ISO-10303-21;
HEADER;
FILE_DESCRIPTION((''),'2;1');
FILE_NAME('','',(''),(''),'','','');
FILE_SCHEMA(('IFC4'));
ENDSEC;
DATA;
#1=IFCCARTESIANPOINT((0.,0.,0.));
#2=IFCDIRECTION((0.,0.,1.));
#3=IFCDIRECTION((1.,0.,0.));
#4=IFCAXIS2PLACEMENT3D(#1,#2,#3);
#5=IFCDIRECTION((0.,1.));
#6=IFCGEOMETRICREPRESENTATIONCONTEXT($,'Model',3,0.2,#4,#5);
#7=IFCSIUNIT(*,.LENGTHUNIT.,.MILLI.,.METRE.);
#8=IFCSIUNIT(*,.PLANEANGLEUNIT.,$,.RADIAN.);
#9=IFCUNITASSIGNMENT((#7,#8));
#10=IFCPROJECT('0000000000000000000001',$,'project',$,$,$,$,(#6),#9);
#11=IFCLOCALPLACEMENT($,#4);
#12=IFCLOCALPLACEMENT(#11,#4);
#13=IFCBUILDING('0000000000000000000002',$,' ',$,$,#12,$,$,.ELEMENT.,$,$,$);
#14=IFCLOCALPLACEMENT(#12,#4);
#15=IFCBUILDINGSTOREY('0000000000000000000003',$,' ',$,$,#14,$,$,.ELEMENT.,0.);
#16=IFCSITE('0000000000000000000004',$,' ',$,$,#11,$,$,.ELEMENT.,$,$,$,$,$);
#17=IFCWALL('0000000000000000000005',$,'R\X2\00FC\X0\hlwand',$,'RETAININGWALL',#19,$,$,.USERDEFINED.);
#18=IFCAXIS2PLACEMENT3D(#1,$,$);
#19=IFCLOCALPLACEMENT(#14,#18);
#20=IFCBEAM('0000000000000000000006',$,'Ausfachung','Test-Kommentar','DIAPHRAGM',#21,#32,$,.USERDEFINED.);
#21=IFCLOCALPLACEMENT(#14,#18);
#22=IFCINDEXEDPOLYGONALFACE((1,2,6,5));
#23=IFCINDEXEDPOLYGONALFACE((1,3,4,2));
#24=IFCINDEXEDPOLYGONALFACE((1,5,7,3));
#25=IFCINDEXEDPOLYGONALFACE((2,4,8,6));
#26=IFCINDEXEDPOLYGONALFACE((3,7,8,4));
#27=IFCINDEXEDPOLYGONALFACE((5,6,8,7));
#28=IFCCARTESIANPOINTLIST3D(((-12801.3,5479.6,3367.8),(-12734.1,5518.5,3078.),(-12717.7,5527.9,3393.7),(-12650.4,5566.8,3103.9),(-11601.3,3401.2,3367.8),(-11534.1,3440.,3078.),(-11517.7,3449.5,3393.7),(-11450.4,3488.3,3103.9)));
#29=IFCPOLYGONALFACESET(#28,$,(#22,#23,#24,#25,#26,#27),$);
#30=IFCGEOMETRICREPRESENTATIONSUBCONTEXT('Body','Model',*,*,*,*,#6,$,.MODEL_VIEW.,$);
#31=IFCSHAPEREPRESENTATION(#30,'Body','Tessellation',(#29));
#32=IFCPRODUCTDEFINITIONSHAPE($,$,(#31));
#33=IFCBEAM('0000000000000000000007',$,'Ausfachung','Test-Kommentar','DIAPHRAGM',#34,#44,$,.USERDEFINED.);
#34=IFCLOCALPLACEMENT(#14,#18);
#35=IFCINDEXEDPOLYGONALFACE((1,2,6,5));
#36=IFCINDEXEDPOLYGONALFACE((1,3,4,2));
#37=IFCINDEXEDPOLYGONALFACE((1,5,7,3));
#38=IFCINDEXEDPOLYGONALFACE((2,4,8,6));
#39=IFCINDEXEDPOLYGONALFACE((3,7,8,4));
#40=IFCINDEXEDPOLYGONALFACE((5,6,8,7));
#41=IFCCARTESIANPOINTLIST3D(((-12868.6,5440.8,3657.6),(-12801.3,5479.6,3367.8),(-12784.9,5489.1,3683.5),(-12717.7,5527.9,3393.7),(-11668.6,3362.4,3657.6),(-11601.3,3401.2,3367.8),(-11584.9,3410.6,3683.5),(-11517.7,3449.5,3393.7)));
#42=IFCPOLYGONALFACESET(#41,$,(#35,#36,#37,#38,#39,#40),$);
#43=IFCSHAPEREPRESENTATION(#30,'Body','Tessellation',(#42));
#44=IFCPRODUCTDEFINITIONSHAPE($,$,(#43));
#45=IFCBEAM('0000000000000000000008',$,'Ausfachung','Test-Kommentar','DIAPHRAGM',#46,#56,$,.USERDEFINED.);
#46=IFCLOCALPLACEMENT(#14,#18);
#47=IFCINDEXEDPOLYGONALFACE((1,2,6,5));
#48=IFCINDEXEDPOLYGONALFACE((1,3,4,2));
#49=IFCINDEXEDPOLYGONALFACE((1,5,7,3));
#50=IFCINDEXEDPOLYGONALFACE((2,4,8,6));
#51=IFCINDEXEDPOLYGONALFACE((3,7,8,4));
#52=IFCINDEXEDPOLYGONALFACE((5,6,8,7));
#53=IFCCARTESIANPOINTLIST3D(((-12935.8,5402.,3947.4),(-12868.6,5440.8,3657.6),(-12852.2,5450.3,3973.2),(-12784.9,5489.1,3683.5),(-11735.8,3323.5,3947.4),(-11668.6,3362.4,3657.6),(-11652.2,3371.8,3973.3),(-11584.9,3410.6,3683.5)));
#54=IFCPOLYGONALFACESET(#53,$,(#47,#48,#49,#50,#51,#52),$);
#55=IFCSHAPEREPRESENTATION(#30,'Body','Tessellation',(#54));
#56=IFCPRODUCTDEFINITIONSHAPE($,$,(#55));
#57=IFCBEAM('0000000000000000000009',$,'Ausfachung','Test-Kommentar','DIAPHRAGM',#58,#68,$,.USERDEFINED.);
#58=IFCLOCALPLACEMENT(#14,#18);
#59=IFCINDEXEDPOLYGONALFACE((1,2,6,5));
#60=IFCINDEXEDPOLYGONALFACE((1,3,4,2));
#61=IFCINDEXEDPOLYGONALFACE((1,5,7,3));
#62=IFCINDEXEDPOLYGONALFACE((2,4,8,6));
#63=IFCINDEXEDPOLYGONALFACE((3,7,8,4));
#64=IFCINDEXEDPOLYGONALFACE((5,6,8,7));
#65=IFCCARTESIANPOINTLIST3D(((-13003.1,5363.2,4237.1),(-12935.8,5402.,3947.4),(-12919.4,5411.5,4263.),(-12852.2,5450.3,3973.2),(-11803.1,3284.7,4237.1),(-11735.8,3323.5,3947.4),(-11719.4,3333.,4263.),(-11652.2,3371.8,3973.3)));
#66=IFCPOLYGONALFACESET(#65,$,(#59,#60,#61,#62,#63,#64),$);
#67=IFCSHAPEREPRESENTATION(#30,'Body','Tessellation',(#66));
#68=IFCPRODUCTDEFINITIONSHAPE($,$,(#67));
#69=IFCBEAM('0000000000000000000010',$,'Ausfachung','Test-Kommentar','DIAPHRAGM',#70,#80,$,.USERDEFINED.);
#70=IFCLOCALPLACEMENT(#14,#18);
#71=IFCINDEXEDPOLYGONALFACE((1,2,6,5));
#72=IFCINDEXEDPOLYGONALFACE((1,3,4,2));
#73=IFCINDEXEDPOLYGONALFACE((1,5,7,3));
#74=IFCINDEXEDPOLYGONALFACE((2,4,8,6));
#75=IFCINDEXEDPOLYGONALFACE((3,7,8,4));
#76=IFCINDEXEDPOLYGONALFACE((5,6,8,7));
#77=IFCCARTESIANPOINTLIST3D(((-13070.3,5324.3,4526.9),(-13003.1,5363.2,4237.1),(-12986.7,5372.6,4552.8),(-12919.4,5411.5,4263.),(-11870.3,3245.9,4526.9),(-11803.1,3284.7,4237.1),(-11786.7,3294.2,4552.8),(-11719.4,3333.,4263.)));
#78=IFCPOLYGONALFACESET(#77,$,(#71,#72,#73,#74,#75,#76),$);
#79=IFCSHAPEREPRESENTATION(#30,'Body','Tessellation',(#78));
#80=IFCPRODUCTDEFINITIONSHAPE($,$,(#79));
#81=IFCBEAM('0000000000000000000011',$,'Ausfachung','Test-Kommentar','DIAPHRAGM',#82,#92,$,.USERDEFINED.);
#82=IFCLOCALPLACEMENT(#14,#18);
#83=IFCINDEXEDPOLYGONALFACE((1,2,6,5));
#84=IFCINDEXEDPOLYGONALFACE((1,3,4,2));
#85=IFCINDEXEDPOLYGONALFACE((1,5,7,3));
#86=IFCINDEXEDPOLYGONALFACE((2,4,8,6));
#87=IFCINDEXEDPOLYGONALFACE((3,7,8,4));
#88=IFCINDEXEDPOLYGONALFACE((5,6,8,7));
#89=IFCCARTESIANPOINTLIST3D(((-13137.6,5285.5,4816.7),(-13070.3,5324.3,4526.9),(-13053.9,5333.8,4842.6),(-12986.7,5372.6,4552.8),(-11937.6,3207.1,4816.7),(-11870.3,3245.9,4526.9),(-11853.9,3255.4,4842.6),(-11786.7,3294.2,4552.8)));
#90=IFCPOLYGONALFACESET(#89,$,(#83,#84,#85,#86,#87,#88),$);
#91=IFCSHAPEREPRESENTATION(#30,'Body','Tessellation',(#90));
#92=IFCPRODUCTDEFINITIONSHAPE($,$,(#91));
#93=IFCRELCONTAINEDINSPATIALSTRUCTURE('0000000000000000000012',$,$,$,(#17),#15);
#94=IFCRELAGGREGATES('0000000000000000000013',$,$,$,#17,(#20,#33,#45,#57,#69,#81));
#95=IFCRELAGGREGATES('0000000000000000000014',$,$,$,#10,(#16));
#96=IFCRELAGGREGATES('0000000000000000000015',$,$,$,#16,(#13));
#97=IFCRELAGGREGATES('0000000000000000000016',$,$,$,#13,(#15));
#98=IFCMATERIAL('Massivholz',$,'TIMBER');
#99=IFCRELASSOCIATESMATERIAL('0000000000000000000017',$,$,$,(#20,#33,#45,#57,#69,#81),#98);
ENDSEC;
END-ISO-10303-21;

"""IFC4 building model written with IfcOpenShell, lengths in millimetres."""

from ifc_helpers import new_model, si_unit, direction, frame, origin_with_axes, place, context, subcontext, project, spatial, line, indexed_curve, outline, extrude, material, element, aggregate, save


model = new_model("IFC4")

# Units and contexts
model_context = context("Model", 3, precision=0.2, world=origin_with_axes(), true_north=direction((0.0, 1.0)))
body_context = subcontext(model_context, "Body", "Model", "MODEL_VIEW")
ifc_project = project(units=[si_unit("LENGTHUNIT", "METRE", prefix="MILLI"), si_unit("PLANEANGLEUNIT", "RADIAN")], contexts=[model_context])

# Site, building, storey
site_placement = place(None, origin_with_axes())
site = spatial("IfcSite", under=ifc_project, at=site_placement, Name=" ", CompositionType="ELEMENT")
building_placement = place(site_placement, origin_with_axes())
building = spatial("IfcBuilding", under=site, at=building_placement, Name=" ", CompositionType="ELEMENT")
storey_placement = place(building_placement, origin_with_axes())
storey = spatial("IfcBuildingStorey", under=building, at=storey_placement, Name=" ", CompositionType="ELEMENT", Elevation=0.0)

# Wall, beams
ifc_material_1 = material(Name="Massivholz", Category="TIMBER")
wall_1_placement = place(storey_placement, frame((-9848.6, 1445.5, 1545.5), z_axis=(-0.836516, -0.482964, -0.258819), x_axis=(0.499999, -0.866026, 0.000005)))
wall_1 = element("IfcWall", 1, at=wall_1_placement, inside=storey, Name="Rühlwand", ObjectType="RETAININGWALL", PredefinedType="USERDEFINED")
beam_1_placement = place(wall_1_placement, frame((-4970.0, 1750.0, 0.0), z_axis=(0.0, 0.0, -1.0), x_axis=(1.0, 0.0, 0.0)))
beam_1 = element("IfcBeam", 2, at=beam_1_placement, material=ifc_material_1, Name="Ausfachung", Description="Test-Kommentar", ObjectType="DIAPHRAGM", PredefinedType="USERDEFINED", context=body_context, shape_type="SolidModel", body=[
    extrude(outline(indexed_curve([(-50.0, -150.0), (50.0, -150.0), (50.0, 150.0), (-50.0, 150.0)], segments=[line(1, 2, 3, 4, 1)])), frame((0.0, 0.0, 0.0), z_axis=(-1.0, 0.0, 0.0), x_axis=(0.0, 0.0, 1.0)), (0.0, 0.0, -1.0), 2400.0),
])
beam_2_placement = place(wall_1_placement, frame((-4970.0, 2050.0, 0.0), z_axis=(0.0, 0.0, -1.0), x_axis=(1.0, 0.0, 0.0)))
beam_2 = element("IfcBeam", 3, at=beam_2_placement, material=ifc_material_1, Name="Ausfachung", Description="Test-Kommentar", ObjectType="DIAPHRAGM", PredefinedType="USERDEFINED", context=body_context, shape_type="SolidModel", body=[
    extrude(outline(indexed_curve([(-50.0, -150.0), (50.0, -150.0), (50.0, 150.0), (-50.0, 150.0)], segments=[line(1, 2, 3, 4, 1)])), frame((0.0, 0.0, 0.0), z_axis=(-1.0, 0.0, 0.0), x_axis=(0.0, 0.0, 1.0)), (0.0, 0.0, -1.0), 2400.0),
])
beam_3_placement = place(wall_1_placement, frame((-4970.0, 2350.0, 0.0), z_axis=(0.0, 0.0, -1.0), x_axis=(1.0, 0.0, 0.0)))
beam_3 = element("IfcBeam", 4, at=beam_3_placement, material=ifc_material_1, Name="Ausfachung", Description="Test-Kommentar", ObjectType="DIAPHRAGM", PredefinedType="USERDEFINED", context=body_context, shape_type="SolidModel", body=[
    extrude(outline(indexed_curve([(-50.0, -150.0), (50.0, -150.0), (50.0, 150.0), (-50.0, 150.0)], segments=[line(1, 2, 3, 4, 1)])), frame((0.0, 0.0, 0.0), z_axis=(-1.0, 0.0, 0.0), x_axis=(0.0, 0.0, 1.0)), (0.0, 0.0, -1.0), 2400.0),
])
beam_4_placement = place(wall_1_placement, frame((-4970.0, 2650.0, 0.0), z_axis=(0.0, 0.0, -1.0), x_axis=(1.0, 0.0, 0.0)))
beam_4 = element("IfcBeam", 5, at=beam_4_placement, material=ifc_material_1, Name="Ausfachung", Description="Test-Kommentar", ObjectType="DIAPHRAGM", PredefinedType="USERDEFINED", context=body_context, shape_type="SolidModel", body=[
    extrude(outline(indexed_curve([(-50.0, -150.0), (50.0, -150.0), (50.0, 150.0), (-50.0, 150.0)], segments=[line(1, 2, 3, 4, 1)])), frame((0.0, 0.0, 0.0), z_axis=(-1.0, 0.0, 0.0), x_axis=(0.0, 0.0, 1.0)), (0.0, 0.0, -1.0), 2400.0),
])
beam_5_placement = place(wall_1_placement, frame((-4970.0, 2950.0, 0.0), z_axis=(0.0, 0.0, -1.0), x_axis=(1.0, 0.0, 0.0)))
beam_5 = element("IfcBeam", 6, at=beam_5_placement, material=ifc_material_1, Name="Ausfachung", Description="Test-Kommentar", ObjectType="DIAPHRAGM", PredefinedType="USERDEFINED", context=body_context, shape_type="SolidModel", body=[
    extrude(outline(indexed_curve([(-50.0, -150.0), (50.0, -150.0), (50.0, 150.0), (-50.0, 150.0)], segments=[line(1, 2, 3, 4, 1)])), frame((0.0, 0.0, 0.0), z_axis=(-1.0, 0.0, 0.0), x_axis=(0.0, 0.0, 1.0)), (0.0, 0.0, -1.0), 2400.0),
])
beam_6_placement = place(wall_1_placement, frame((-4970.0, 3250.0, 0.0), z_axis=(0.0, 0.0, -1.0), x_axis=(1.0, 0.0, 0.0)))
beam_6 = element("IfcBeam", 7, at=beam_6_placement, material=ifc_material_1, Name="Ausfachung", Description="Test-Kommentar", ObjectType="DIAPHRAGM", PredefinedType="USERDEFINED", context=body_context, shape_type="SolidModel", body=[
    extrude(outline(indexed_curve([(-50.0, -150.0), (50.0, -150.0), (50.0, 150.0), (-50.0, 150.0)], segments=[line(1, 2, 3, 4, 1)])), frame((0.0, 0.0, 0.0), z_axis=(-1.0, 0.0, 0.0), x_axis=(0.0, 0.0, 1.0)), (0.0, 0.0, -1.0), 2400.0),
])

aggregate(wall_1, [beam_1, beam_2, beam_3, beam_4, beam_5, beam_6])

save(model, "model.ifc")
